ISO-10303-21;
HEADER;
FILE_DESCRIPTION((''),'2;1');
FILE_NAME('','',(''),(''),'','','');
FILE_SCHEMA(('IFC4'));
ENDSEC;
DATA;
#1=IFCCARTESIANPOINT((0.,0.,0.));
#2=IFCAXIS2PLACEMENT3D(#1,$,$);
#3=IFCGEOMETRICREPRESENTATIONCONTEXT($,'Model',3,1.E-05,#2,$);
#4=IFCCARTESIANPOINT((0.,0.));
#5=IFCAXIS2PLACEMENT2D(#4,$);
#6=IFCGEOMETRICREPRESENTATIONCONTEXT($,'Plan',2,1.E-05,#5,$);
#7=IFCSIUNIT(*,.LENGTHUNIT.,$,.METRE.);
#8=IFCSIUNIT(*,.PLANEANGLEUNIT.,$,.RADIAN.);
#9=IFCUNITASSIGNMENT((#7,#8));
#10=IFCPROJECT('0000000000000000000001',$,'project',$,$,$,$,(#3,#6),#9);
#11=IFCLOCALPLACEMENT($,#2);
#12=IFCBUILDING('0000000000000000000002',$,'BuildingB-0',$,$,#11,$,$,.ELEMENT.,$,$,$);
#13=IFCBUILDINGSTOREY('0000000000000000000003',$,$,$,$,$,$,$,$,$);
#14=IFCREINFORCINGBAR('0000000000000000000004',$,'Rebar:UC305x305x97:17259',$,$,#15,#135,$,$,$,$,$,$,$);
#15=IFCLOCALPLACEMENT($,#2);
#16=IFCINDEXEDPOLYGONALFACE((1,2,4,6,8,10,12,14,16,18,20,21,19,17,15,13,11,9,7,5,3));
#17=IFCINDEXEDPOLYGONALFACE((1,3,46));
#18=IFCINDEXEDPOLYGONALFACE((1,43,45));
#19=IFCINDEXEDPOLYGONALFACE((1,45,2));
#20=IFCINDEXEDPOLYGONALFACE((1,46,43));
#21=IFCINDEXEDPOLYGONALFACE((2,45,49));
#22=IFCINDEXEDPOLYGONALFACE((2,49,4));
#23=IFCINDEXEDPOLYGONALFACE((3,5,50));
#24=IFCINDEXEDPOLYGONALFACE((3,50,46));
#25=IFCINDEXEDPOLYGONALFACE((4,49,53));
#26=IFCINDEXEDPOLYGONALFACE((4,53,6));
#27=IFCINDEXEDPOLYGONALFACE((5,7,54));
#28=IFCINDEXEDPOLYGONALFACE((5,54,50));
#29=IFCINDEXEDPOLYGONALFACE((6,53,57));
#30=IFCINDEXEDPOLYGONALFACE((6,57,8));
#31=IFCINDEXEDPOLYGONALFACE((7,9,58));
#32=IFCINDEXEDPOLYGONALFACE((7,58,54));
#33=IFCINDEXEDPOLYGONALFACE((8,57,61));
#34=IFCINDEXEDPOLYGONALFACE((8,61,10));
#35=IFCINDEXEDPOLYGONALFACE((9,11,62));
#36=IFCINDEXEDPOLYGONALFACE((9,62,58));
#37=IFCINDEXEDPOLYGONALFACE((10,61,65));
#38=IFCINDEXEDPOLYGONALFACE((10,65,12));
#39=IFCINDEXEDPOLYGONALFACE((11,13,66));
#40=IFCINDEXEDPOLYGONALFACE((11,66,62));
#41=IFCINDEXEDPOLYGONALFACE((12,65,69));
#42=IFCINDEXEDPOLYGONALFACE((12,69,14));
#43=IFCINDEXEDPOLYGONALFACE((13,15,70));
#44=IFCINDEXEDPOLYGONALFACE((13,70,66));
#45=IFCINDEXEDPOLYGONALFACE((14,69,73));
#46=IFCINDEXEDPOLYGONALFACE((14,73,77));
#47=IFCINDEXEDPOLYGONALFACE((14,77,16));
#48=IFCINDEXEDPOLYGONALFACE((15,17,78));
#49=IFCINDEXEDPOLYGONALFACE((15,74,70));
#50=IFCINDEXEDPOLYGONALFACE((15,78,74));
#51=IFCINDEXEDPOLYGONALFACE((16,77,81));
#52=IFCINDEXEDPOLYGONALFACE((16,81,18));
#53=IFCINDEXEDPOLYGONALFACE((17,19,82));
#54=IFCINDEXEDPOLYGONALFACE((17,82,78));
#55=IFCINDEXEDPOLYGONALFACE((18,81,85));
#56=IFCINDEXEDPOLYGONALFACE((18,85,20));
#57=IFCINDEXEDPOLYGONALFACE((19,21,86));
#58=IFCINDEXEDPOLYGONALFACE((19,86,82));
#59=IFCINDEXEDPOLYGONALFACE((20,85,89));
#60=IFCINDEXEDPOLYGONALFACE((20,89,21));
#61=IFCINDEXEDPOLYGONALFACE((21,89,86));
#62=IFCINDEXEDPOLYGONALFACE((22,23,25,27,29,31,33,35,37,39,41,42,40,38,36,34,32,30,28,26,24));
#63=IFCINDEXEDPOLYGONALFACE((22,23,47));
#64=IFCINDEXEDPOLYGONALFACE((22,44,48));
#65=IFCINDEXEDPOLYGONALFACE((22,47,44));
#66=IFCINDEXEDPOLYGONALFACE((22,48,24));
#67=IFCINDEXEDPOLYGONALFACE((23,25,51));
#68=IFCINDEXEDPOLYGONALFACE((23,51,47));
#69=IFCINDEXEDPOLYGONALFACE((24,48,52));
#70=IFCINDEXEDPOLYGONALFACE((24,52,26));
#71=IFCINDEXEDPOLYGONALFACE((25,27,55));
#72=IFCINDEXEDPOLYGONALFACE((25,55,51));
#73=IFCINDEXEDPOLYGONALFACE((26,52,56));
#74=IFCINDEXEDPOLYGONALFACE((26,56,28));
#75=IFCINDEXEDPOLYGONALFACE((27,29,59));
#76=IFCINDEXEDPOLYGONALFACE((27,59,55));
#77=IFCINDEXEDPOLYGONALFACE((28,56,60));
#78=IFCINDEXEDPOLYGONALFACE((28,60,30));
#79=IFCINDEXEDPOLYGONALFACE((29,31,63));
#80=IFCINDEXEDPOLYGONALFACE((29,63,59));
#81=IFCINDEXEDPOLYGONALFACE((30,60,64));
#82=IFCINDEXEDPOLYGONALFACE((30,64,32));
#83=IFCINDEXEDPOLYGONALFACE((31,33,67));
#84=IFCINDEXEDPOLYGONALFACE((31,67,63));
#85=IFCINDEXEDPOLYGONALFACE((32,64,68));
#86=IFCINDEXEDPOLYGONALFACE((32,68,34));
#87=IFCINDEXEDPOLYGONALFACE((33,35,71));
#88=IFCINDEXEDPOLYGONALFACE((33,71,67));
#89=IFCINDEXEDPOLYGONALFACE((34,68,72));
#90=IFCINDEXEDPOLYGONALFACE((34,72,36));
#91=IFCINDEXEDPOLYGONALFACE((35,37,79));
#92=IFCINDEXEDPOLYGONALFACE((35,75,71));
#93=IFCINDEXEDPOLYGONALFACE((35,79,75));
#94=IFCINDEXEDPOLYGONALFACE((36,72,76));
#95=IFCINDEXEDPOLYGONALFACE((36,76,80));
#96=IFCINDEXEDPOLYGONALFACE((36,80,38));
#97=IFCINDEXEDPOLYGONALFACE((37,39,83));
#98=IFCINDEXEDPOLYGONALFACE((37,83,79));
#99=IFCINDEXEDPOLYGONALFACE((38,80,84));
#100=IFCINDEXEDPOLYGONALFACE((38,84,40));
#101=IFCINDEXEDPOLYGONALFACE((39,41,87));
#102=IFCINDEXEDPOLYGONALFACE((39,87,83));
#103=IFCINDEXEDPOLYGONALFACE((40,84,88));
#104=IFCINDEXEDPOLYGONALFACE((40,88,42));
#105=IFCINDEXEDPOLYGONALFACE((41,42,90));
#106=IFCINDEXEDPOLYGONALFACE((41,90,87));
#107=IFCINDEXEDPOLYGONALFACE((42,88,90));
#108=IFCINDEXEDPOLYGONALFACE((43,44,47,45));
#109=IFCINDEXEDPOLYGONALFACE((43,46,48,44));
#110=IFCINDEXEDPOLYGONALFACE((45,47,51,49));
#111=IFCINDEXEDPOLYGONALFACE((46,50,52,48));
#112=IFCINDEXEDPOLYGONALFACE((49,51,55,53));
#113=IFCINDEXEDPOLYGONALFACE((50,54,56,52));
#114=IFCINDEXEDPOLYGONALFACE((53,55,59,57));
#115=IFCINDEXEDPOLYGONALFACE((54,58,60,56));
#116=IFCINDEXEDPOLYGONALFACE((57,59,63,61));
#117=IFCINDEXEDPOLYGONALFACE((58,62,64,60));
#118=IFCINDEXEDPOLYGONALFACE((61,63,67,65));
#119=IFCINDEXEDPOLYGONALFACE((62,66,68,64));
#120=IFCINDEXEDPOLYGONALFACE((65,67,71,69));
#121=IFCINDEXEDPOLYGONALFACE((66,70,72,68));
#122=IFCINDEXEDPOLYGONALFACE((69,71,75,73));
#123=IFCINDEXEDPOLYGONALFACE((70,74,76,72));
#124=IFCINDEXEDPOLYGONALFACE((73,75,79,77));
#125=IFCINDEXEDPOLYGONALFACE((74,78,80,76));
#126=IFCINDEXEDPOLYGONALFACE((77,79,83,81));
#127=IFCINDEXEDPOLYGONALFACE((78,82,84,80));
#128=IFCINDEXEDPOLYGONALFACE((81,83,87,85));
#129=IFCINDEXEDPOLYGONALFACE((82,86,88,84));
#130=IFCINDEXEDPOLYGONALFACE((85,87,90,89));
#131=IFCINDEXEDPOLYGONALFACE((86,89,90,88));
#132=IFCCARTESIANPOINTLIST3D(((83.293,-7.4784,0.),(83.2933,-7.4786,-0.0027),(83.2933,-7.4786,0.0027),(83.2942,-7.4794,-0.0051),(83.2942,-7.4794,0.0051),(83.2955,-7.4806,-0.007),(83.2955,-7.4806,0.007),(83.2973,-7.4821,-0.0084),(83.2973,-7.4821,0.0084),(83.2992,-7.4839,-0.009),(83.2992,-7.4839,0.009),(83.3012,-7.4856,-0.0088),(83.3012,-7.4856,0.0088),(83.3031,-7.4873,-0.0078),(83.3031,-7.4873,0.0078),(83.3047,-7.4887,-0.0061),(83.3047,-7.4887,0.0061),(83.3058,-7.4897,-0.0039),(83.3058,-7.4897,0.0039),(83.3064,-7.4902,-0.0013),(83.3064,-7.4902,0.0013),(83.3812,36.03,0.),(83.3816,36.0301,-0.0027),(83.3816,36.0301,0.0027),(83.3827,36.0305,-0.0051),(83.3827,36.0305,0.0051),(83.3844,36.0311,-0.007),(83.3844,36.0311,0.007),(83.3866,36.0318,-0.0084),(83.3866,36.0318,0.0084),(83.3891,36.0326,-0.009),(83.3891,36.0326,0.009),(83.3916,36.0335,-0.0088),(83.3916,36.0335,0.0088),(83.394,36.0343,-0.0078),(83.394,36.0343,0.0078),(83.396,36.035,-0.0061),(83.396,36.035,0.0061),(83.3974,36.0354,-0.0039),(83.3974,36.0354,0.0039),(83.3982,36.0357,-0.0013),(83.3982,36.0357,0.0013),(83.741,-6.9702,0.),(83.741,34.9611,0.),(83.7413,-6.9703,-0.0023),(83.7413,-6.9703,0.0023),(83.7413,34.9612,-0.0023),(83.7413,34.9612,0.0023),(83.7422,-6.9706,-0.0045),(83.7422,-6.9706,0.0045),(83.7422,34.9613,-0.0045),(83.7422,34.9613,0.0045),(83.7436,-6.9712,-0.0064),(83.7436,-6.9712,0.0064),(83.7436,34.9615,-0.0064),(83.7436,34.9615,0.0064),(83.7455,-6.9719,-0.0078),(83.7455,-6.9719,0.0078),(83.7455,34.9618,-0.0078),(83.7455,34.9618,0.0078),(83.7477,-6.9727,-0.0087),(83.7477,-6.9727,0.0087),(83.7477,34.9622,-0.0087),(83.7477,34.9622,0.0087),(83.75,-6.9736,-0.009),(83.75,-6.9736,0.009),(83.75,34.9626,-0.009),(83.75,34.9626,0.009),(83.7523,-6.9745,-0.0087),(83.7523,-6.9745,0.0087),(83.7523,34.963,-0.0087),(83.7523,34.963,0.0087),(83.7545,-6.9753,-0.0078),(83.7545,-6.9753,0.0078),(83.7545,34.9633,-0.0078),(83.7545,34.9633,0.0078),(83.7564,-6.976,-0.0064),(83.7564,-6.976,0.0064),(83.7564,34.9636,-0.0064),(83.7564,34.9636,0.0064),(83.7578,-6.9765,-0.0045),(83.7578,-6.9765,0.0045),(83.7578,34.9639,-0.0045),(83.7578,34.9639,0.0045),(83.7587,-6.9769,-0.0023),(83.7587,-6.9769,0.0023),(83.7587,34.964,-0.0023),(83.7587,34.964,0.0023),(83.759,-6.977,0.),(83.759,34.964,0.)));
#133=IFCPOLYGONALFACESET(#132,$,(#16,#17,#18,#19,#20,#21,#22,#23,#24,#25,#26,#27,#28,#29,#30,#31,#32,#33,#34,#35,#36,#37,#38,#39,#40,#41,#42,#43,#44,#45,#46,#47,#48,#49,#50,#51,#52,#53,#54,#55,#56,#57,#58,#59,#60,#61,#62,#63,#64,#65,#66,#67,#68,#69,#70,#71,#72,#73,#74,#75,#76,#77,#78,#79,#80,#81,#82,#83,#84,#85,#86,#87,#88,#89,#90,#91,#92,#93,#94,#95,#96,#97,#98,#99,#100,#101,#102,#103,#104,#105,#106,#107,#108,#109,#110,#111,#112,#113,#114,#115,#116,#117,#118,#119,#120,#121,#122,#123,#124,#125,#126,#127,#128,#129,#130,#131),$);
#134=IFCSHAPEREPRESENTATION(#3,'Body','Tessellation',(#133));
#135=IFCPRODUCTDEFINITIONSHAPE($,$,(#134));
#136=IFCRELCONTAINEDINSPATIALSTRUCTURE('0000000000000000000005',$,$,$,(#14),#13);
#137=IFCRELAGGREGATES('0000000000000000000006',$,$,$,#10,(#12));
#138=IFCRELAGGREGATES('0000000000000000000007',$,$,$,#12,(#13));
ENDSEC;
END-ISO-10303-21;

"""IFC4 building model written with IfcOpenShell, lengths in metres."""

from ifc_helpers import new_model, entity, si_unit, origin, origin_2d, place, context, project, spatial, element, save


model = new_model("IFC4")

# Units and contexts
model_context = context("Model", 3, precision=1e-05, world=origin())
plan_context = context("Plan", 2, precision=1e-05, world=origin_2d())
ifc_project = project(units=[si_unit("LENGTHUNIT", "METRE"), si_unit("PLANEANGLEUNIT", "RADIAN")], contexts=[model_context, plan_context])

# Building, storey
building_placement = place(None, origin())
building = spatial("IfcBuilding", under=ifc_project, at=building_placement, Name="BuildingB-0", CompositionType="ELEMENT")
storey = spatial("IfcBuildingStorey", under=building)

# Reinforcing bar
element("IfcReinforcingBar", 1, inside=storey, Name="Rebar:UC305x305x97:17259", context=model_context, shape_type="SweptSolid", body=[
    entity("IfcSurfaceCurveSweptAreaSolid", entity("IfcCircleProfileDef", "AREA", None, None, 0.009), None, entity("IfcPolyline", [entity("IfcCartesianPoint", [83.3897, 36.0329, 0.0]), entity("IfcCartesianPoint", [83.75, 34.9626, 0.0]), entity("IfcCartesianPoint", [83.75, -6.9736, 0.0]), entity("IfcCartesianPoint", [83.2997, -7.4843, 0.0])]), None, None, entity("IfcPlane", entity("IfcAxis2Placement3D", entity("IfcCartesianPoint", [83.3897, 36.0329, 0.0]), entity("IfcDirection", [1.0, -0.000167, 0.0]), entity("IfcDirection", [0.0, -1.0, 0.0])))),
])

save(model, "model.ifc")
